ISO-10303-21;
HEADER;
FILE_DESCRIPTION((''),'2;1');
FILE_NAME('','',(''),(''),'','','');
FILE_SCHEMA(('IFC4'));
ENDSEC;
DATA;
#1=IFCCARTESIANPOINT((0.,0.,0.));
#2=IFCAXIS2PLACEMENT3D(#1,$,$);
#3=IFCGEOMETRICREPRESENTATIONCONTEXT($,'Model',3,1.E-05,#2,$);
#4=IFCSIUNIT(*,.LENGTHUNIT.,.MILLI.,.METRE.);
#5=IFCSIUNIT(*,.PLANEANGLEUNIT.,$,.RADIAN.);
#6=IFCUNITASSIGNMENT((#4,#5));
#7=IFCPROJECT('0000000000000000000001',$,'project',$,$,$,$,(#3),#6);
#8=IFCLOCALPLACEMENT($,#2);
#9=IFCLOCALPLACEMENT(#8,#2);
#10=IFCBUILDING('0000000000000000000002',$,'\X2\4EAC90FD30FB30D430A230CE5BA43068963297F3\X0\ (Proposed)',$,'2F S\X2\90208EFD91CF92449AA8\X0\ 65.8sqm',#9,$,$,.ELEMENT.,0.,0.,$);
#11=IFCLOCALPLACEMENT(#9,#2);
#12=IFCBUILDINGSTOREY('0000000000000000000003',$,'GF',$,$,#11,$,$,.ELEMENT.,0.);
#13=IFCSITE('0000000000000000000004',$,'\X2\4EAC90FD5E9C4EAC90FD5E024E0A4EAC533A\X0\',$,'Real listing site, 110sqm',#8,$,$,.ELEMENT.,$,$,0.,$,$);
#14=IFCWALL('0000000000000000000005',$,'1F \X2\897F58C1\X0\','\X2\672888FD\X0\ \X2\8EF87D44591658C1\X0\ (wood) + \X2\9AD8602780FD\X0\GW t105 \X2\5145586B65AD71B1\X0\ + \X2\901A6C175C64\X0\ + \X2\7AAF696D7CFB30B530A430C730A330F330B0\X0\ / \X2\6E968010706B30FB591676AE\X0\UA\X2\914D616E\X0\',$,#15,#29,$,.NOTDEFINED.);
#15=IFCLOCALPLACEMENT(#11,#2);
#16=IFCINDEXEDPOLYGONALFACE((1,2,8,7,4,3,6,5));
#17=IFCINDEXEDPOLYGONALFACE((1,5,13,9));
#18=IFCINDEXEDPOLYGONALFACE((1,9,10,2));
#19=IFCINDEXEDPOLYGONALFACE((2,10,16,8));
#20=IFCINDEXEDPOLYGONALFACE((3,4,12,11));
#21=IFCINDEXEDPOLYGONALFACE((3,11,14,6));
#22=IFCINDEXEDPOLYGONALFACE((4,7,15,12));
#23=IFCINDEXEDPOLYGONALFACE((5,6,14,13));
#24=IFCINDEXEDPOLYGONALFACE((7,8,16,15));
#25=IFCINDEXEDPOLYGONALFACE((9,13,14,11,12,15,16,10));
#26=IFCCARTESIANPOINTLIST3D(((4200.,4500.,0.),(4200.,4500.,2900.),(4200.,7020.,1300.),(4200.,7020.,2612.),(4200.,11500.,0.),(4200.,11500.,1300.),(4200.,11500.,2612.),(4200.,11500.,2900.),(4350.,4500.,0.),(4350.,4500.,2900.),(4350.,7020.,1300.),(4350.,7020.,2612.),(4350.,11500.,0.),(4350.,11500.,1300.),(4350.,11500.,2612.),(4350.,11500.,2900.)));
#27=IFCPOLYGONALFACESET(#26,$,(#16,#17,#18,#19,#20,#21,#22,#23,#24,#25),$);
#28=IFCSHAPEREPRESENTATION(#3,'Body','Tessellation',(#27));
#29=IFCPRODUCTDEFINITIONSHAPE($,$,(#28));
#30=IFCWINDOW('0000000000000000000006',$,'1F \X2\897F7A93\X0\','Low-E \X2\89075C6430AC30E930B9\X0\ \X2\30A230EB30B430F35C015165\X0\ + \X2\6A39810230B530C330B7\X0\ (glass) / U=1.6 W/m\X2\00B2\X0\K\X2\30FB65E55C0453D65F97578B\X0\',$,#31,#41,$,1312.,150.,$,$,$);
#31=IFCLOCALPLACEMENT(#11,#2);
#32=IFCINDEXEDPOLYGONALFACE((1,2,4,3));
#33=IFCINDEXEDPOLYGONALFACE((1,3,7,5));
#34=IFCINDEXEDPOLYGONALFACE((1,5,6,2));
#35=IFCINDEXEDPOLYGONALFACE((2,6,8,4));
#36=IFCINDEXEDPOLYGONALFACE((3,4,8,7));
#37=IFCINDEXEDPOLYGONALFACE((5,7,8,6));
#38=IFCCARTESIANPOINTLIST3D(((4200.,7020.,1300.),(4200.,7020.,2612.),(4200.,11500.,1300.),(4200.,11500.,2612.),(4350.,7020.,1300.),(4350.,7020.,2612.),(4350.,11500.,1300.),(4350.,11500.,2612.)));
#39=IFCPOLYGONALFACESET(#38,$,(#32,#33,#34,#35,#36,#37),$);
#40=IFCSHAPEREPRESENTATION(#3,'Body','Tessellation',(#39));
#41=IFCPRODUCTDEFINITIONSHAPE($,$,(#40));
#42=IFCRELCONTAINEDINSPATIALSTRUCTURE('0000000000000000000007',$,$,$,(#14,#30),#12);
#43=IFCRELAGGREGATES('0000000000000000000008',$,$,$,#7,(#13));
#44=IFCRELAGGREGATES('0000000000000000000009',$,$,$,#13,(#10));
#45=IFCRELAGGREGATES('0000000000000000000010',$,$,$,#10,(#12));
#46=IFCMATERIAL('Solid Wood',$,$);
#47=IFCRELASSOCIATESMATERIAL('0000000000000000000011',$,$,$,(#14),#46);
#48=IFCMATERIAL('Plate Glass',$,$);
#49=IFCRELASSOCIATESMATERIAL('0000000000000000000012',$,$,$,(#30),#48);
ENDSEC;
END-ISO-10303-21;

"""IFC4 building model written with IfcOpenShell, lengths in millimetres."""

from ifc_helpers import new_model, si_unit, frame, frame_2d, origin, place, context, project, spatial, rectangle, extrude, material, element, fill, save


model = new_model("IFC4")

# Units and contexts
model_context = context("Model", 3, precision=1e-05, world=origin())
ifc_project = project(units=[si_unit("LENGTHUNIT", "METRE", prefix="MILLI"), si_unit("PLANEANGLEUNIT", "RADIAN")], contexts=[model_context])

# Site, building, storey
site_placement = place(None, origin())
site = spatial("IfcSite", under=ifc_project, at=site_placement, Name="京都府京都市上京区", ObjectType="Real listing site, 110sqm", CompositionType="ELEMENT", RefElevation=0.0)
building_placement = place(site_placement, origin())
building = spatial("IfcBuilding", under=site, at=building_placement, Name="京都・ピアノ室と防音 (Proposed)", ObjectType="2F S造軽量鉄骨 65.8sqm", CompositionType="ELEMENT", ElevationOfRefHeight=0.0, ElevationOfTerrain=0.0)
storey_placement = place(building_placement, origin())
storey = spatial("IfcBuildingStorey", under=building, at=storey_placement, Name="GF", CompositionType="ELEMENT", Elevation=0.0)

# Shared definitions
ifc_material_1 = material(Name="Solid Wood")

# Shared definitions
ifc_material_2 = material(Name="Plate Glass")

# Wall, opening, window
wall_1_placement = place(storey_placement, frame((2100.0, 2250.0, 0.0)))
wall_1 = element("IfcWall", 1, at=wall_1_placement, inside=storey, material=ifc_material_1, Name="1F 西壁", Description="木製 軸組外壁 (wood) + 高性能GW t105 充填断熱 + 通気層 + 窯業系サイディング / 準耐火・外皮UA配慮", PredefinedType="NOTDEFINED", context=model_context, shape_type="SweptSolid", body=[
    extrude(rectangle(XDim=150.0, YDim=7000.0, at=frame_2d((75.0, 3500.0))), frame((2100.0, 2250.0, 0.0)), (0.0, 0.0, 1.0), 2900.0),
])
opening_1_placement = place(storey_placement, frame((2100.0, 3510.0, 650.0)))
opening_1 = element("IfcOpeningElement", 2, at=opening_1_placement, cuts=wall_1, PredefinedType="NOTDEFINED", context=model_context, shape_type="SweptSolid", body=[
    extrude(rectangle(XDim=150.0, YDim=4480.0, at=frame_2d((75.0, 2240.0))), frame((2100.0, 3510.0, 650.0)), (0.0, 0.0, 1.0), 1312.0),
])
window_1_placement = place(storey_placement, frame((2100.0, 3510.0, 650.0)))
window_1 = element("IfcWindow", 3, at=window_1_placement, inside=storey, material=ifc_material_2, Name="1F 西窓", Description="Low-E 複層ガラス アルゴン封入 + 樹脂サッシ (glass) / U=1.6 W/m²K・日射取得型", OverallHeight=1312.0, OverallWidth=150.0, context=model_context, shape_type="SweptSolid", body=[
    extrude(rectangle(XDim=150.0, YDim=4480.0, at=frame_2d((75.0, 2240.0))), frame((2100.0, 3510.0, 650.0)), (0.0, 0.0, 1.0), 1312.0),
])
fill(opening_1, window_1)

save(model, "model.ifc")
